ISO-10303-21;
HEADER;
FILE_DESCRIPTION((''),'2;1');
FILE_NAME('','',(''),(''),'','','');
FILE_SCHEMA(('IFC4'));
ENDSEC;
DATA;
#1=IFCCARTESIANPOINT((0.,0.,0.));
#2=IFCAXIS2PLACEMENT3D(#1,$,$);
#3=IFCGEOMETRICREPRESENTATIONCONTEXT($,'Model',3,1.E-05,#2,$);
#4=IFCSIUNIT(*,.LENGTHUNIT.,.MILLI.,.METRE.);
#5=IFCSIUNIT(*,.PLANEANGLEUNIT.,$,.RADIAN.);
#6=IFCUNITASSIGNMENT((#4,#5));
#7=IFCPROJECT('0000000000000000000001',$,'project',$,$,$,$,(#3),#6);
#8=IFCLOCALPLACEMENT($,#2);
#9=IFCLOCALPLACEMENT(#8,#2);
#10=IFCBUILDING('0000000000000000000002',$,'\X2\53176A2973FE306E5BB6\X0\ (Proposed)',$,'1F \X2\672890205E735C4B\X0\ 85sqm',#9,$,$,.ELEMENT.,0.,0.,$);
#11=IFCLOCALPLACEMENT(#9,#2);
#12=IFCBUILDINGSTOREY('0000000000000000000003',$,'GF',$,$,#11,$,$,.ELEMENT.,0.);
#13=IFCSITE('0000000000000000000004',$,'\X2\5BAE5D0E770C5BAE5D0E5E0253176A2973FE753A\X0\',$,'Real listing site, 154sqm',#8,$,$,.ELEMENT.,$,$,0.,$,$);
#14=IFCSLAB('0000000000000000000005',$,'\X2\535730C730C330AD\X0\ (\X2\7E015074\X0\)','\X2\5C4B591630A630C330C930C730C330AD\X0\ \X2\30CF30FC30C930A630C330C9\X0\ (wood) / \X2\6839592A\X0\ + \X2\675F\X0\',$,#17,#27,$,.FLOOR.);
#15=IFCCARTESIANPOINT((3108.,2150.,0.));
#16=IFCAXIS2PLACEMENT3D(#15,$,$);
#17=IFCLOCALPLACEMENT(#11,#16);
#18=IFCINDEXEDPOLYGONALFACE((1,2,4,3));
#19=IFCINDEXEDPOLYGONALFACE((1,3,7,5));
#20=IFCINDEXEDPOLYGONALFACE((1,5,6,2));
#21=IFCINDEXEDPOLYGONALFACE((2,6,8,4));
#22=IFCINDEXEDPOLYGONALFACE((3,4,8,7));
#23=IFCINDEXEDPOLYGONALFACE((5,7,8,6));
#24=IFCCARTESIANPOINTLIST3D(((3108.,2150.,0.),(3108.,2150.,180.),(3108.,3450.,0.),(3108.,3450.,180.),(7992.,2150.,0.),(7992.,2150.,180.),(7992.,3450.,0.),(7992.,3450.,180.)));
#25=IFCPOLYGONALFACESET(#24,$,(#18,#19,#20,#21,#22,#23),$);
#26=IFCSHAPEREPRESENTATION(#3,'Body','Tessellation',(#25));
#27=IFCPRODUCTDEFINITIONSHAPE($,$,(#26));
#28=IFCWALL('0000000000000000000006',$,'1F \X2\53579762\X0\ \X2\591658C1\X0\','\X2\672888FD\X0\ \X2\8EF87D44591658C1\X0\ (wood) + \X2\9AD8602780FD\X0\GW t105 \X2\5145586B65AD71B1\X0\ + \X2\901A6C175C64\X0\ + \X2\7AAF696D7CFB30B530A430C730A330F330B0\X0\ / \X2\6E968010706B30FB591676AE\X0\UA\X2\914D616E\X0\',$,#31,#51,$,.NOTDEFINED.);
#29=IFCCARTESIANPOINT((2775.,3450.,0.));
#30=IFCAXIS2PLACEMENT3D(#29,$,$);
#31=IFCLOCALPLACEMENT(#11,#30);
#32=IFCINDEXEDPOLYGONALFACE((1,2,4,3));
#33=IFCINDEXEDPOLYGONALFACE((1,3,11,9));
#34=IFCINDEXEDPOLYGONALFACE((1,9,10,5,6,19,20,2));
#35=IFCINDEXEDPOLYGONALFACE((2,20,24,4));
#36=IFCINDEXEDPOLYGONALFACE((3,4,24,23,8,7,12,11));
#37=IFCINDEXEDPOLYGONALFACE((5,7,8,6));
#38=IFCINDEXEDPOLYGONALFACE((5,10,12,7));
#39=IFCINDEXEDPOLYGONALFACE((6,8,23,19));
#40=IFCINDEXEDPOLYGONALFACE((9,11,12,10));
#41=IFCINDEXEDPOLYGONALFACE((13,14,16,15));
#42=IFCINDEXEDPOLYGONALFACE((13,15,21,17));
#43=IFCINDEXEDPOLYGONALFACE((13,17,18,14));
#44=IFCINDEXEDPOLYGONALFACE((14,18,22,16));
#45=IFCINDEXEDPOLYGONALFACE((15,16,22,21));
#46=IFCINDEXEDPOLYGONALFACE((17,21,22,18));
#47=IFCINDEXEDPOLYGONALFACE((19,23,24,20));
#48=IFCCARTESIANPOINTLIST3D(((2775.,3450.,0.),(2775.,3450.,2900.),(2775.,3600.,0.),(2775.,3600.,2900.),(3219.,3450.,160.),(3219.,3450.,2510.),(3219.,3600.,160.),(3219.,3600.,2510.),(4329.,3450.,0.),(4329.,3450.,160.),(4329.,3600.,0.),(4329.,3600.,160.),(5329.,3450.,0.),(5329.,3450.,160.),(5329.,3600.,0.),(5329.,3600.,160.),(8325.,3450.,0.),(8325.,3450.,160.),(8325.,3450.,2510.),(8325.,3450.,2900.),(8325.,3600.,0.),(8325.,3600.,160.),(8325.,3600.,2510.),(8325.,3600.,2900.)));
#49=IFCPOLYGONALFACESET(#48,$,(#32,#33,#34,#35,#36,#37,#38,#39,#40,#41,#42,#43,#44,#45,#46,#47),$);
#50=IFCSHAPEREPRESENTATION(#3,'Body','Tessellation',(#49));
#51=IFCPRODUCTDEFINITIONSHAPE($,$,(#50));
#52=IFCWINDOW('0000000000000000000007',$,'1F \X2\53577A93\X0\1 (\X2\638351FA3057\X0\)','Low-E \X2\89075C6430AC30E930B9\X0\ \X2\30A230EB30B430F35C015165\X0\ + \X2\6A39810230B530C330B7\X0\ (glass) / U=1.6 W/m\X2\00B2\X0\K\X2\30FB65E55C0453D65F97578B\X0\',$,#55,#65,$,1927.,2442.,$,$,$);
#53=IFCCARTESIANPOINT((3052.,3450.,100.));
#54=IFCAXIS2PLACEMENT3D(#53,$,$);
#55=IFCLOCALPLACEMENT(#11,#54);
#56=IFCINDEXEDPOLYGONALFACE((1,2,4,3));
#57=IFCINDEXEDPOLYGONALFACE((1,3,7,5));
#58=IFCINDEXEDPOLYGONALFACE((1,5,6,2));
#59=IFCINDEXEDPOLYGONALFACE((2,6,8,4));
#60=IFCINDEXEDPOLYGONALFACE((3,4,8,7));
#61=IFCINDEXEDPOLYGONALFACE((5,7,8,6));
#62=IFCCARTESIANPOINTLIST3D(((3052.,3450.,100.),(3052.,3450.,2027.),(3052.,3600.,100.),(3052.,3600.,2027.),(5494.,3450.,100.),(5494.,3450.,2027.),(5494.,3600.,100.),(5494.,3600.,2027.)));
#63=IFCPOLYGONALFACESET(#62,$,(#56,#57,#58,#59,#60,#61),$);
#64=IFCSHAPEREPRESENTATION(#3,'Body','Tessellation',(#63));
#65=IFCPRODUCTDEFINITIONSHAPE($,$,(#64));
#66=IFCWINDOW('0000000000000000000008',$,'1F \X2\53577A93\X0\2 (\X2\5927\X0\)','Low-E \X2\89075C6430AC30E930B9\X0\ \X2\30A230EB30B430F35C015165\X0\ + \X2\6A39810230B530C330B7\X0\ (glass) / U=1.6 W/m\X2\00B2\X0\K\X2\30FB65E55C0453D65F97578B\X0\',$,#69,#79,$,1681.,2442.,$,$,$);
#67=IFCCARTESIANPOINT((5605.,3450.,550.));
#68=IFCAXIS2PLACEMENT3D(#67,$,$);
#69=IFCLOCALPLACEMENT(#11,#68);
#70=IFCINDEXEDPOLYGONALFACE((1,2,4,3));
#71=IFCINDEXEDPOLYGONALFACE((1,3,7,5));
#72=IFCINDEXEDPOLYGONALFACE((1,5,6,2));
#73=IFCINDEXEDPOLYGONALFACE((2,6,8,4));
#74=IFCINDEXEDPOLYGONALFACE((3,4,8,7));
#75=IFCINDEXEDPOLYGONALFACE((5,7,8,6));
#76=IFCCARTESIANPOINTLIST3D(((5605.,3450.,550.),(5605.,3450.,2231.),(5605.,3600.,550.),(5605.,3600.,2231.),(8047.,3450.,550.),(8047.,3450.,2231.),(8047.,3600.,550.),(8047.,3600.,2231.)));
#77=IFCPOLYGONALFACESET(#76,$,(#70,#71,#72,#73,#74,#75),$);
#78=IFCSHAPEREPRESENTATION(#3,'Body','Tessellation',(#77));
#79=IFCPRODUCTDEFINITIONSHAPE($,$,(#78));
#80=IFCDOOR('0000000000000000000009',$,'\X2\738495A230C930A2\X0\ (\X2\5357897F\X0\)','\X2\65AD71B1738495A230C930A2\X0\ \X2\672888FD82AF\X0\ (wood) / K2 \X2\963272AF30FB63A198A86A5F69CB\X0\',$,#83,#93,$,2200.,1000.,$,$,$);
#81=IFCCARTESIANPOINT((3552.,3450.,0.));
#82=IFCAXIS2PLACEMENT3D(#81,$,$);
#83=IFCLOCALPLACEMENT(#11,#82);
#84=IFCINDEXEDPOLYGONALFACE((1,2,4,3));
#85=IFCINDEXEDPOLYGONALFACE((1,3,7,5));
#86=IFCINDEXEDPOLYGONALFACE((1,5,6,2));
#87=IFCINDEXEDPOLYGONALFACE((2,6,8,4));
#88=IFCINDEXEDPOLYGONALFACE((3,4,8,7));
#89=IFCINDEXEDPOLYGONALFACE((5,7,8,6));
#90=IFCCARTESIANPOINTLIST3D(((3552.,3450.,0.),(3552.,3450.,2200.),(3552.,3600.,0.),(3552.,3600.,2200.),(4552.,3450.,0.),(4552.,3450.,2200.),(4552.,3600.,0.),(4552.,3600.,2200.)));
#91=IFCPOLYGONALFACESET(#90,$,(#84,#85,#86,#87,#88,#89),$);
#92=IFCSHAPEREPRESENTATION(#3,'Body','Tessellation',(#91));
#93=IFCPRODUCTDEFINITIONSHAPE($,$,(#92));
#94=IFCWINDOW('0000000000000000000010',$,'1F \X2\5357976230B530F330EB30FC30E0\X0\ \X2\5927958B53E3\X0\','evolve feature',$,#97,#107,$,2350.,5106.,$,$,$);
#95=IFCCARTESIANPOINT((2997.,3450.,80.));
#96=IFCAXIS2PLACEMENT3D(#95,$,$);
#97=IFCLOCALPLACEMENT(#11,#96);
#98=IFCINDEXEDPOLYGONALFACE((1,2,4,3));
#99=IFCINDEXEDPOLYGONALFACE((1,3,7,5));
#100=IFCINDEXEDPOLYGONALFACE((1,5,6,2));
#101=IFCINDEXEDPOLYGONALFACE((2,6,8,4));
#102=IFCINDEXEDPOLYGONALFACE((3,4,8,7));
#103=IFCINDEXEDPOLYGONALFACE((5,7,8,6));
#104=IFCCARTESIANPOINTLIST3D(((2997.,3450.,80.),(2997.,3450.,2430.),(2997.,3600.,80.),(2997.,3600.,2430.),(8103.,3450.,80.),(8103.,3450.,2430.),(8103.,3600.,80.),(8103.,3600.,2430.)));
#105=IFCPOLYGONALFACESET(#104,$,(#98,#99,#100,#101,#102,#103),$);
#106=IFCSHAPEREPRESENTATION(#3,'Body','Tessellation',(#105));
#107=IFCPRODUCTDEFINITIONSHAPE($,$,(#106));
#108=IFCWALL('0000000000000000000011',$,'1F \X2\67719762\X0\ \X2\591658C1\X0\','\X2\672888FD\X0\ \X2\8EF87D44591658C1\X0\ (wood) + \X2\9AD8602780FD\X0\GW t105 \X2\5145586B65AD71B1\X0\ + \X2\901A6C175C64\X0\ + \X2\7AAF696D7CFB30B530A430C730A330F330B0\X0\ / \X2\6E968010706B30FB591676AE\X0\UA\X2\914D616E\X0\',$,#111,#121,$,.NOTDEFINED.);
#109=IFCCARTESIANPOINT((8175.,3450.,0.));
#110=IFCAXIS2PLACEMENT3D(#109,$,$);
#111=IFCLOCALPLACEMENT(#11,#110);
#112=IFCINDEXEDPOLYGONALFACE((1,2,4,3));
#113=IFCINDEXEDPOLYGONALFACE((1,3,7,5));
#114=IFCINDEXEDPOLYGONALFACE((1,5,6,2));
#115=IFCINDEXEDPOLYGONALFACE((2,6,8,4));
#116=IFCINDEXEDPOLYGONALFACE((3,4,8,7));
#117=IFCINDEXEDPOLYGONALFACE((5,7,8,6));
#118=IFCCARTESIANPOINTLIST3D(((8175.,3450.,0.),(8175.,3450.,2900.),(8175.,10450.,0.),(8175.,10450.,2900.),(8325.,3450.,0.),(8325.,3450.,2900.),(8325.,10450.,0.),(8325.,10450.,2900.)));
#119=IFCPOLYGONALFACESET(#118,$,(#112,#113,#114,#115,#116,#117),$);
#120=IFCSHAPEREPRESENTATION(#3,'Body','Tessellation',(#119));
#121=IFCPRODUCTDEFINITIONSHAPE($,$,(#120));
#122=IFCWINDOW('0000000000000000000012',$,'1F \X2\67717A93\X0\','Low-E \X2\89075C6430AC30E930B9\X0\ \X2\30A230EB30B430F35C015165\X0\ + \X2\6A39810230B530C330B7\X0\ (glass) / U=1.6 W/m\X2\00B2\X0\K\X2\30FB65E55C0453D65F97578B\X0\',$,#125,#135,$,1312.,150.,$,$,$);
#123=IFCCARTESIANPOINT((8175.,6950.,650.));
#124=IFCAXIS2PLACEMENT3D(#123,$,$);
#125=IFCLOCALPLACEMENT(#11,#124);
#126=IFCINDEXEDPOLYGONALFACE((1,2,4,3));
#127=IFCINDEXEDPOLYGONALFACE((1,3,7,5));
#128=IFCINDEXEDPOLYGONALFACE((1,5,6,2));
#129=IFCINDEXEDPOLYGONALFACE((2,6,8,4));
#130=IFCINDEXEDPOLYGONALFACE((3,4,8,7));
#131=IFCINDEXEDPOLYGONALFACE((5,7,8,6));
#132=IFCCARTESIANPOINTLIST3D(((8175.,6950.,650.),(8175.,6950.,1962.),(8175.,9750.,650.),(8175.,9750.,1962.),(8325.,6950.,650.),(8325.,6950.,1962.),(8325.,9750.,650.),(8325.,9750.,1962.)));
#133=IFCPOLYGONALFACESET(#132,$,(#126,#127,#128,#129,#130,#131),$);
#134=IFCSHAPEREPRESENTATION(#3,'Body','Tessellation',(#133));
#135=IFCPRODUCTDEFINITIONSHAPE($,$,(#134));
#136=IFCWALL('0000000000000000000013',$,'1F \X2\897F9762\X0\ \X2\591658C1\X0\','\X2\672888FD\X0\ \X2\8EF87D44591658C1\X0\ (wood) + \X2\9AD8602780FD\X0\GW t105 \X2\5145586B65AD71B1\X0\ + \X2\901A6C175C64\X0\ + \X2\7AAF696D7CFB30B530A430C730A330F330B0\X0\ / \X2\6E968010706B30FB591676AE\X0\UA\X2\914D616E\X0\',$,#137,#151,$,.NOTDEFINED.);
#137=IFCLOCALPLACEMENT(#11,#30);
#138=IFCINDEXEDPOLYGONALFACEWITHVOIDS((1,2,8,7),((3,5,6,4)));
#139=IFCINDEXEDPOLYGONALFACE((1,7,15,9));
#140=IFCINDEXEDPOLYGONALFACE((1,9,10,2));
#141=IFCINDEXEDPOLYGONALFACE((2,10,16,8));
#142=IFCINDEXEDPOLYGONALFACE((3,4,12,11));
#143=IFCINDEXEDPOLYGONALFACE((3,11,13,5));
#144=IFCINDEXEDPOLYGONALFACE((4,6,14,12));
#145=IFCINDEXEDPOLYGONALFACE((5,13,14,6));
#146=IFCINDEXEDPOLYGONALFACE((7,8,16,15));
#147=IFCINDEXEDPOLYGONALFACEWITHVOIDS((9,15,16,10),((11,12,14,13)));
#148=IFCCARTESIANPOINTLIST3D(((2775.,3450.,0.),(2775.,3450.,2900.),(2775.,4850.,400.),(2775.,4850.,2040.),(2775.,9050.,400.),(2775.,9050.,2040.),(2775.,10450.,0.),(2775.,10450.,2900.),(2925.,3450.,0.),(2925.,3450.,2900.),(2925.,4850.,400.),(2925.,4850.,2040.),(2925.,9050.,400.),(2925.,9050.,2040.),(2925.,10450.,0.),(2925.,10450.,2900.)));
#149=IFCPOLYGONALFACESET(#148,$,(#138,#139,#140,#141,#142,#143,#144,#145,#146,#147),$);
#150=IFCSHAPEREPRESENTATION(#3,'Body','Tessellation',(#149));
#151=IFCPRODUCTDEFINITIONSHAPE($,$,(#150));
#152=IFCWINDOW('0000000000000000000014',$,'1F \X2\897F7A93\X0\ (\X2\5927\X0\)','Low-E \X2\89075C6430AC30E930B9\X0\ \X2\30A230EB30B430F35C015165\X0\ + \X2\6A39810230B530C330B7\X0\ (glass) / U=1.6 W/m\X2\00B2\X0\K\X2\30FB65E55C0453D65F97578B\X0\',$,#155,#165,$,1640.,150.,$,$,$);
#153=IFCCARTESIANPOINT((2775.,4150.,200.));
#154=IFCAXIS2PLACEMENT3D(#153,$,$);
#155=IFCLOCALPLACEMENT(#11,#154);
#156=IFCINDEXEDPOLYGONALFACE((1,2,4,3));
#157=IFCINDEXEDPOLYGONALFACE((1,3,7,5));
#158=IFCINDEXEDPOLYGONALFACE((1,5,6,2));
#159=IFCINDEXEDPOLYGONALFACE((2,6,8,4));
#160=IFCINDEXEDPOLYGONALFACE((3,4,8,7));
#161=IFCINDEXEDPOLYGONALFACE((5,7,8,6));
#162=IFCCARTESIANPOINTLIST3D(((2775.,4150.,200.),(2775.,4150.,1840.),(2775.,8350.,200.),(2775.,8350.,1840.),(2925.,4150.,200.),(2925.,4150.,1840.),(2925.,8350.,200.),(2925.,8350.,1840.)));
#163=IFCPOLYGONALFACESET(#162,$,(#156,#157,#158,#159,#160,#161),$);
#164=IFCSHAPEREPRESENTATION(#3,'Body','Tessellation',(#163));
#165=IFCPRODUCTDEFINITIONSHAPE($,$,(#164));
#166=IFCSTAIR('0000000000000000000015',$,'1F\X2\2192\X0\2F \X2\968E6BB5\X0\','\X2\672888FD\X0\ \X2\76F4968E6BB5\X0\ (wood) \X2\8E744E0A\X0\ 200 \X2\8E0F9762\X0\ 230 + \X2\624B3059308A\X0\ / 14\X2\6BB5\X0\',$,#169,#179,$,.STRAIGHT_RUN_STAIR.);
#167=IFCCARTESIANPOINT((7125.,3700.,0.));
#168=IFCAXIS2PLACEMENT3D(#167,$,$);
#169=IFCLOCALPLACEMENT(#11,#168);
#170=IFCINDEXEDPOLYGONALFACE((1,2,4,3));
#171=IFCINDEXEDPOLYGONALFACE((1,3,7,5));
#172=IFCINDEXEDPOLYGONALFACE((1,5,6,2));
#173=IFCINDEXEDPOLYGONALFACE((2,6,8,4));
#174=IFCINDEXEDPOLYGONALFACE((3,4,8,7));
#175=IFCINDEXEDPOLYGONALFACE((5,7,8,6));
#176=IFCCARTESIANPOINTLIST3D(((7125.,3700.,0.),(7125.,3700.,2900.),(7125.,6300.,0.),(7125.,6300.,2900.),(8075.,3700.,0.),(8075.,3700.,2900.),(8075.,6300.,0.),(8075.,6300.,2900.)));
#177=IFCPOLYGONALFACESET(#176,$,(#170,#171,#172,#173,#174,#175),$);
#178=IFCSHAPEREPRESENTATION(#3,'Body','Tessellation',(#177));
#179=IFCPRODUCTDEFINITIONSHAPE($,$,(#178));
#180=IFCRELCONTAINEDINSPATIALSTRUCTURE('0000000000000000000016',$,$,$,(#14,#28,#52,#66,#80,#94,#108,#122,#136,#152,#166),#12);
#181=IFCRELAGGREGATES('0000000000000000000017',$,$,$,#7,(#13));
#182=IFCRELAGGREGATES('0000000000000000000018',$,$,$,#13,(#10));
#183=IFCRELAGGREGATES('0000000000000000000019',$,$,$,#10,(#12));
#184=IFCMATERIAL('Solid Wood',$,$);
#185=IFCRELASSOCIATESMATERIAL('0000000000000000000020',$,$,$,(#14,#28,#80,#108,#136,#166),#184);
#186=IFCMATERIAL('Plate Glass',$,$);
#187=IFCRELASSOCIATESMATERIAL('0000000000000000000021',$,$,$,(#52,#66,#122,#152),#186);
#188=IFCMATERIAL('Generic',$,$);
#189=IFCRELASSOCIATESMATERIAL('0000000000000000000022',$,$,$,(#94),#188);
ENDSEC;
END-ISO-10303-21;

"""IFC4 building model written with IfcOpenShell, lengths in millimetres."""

from ifc_helpers import new_model, si_unit, frame, frame_2d, origin, place, context, project, spatial, rectangle, extrude, material, element, fill, save


model = new_model("IFC4")

# Units and contexts
model_context = context("Model", 3, precision=1e-05, world=origin())
ifc_project = project(units=[si_unit("LENGTHUNIT", "METRE", prefix="MILLI"), si_unit("PLANEANGLEUNIT", "RADIAN")], contexts=[model_context])

# Site, building, storey
site_placement = place(None, origin())
site = spatial("IfcSite", under=ifc_project, at=site_placement, Name="宮崎県宮崎市北権現町", ObjectType="Real listing site, 154sqm", CompositionType="ELEMENT", RefElevation=0.0)
building_placement = place(site_placement, origin())
building = spatial("IfcBuilding", under=site, at=building_placement, Name="北権現の家 (Proposed)", ObjectType="1F 木造平屋 85sqm", CompositionType="ELEMENT", ElevationOfRefHeight=0.0, ElevationOfTerrain=0.0)
storey_placement = place(building_placement, origin())
storey = spatial("IfcBuildingStorey", under=building, at=storey_placement, Name="GF", CompositionType="ELEMENT", Elevation=0.0)

# Slab
ifc_material_1 = material(Name="Solid Wood")
slab_1_placement = place(storey_placement, frame((3108.0, 2150.0, 0.0)))
element("IfcSlab", 1, at=slab_1_placement, inside=storey, material=ifc_material_1, Name="南デッキ (縁側)", Description="屋外ウッドデッキ ハードウッド (wood) / 根太 + 束", PredefinedType="FLOOR", context=model_context, shape_type="SweptSolid", body=[
    extrude(rectangle(XDim=4884.0, YDim=1300.0, at=frame_2d((2442.0, 650.0))), frame((3108.0, 2150.0, 0.0)), (0.0, 0.0, 1.0), 180.0),
])
ifc_material_2 = material(Name="Generic")

# Wall, openings, windows, door
wall_1_placement = place(storey_placement, frame((2775.0, 3450.0, 0.0)))
wall_1 = element("IfcWall", 2, at=wall_1_placement, inside=storey, material=ifc_material_1, Name="1F 南面 外壁", Description="木製 軸組外壁 (wood) + 高性能GW t105 充填断熱 + 通気層 + 窯業系サイディング / 準耐火・外皮UA配慮", PredefinedType="NOTDEFINED", context=model_context, shape_type="SweptSolid", body=[
    extrude(rectangle(XDim=5550.0, YDim=150.0, at=frame_2d((2775.0, 75.0))), frame((2775.0, 3450.0, 0.0)), (0.0, 0.0, 1.0), 2900.0),
])
opening_1_placement = place(storey_placement, frame((3052.0, 3450.0, 100.0)))
opening_1 = element("IfcOpeningElement", 3, at=opening_1_placement, cuts=wall_1, PredefinedType="NOTDEFINED", context=model_context, shape_type="SweptSolid", body=[
    extrude(rectangle(XDim=2442.0, YDim=150.0, at=frame_2d((1221.0, 75.0))), frame((3052.0, 3450.0, 100.0)), (0.0, 0.0, 1.0), 1927.0),
])
opening_2_placement = place(storey_placement, frame((5605.0, 3450.0, 550.0)))
opening_2 = element("IfcOpeningElement", 4, at=opening_2_placement, cuts=wall_1, PredefinedType="NOTDEFINED", context=model_context, shape_type="SweptSolid", body=[
    extrude(rectangle(XDim=2442.0, YDim=150.0, at=frame_2d((1221.0, 75.0))), frame((5605.0, 3450.0, 550.0)), (0.0, 0.0, 1.0), 1681.0),
])
opening_3_placement = place(storey_placement, frame((3552.0, 3450.0, 0.0)))
opening_3 = element("IfcOpeningElement", 5, at=opening_3_placement, cuts=wall_1, PredefinedType="NOTDEFINED", context=model_context, shape_type="SweptSolid", body=[
    extrude(rectangle(XDim=1000.0, YDim=150.0, at=frame_2d((500.0, 75.0))), frame((3552.0, 3450.0, 0.0)), (0.0, 0.0, 1.0), 2200.0),
])
opening_4_placement = place(storey_placement, frame((2997.0, 3450.0, 80.0)))
opening_4 = element("IfcOpeningElement", 6, at=opening_4_placement, cuts=wall_1, PredefinedType="NOTDEFINED", context=model_context, shape_type="SweptSolid", body=[
    extrude(rectangle(XDim=5106.0, YDim=150.0, at=frame_2d((2553.0, 75.0))), frame((2997.0, 3450.0, 80.0)), (0.0, 0.0, 1.0), 2350.0),
])
ifc_material_3 = material(Name="Plate Glass")
window_1_placement = place(storey_placement, frame((3052.0, 3450.0, 100.0)))
window_1 = element("IfcWindow", 7, at=window_1_placement, inside=storey, material=ifc_material_3, Name="1F 南窓1 (掃出し)", Description="Low-E 複層ガラス アルゴン封入 + 樹脂サッシ (glass) / U=1.6 W/m²K・日射取得型", OverallHeight=1927.0, OverallWidth=2442.0, context=model_context, shape_type="SweptSolid", body=[
    extrude(rectangle(XDim=2442.0, YDim=150.0, at=frame_2d((1221.0, 75.0))), frame((3052.0, 3450.0, 100.0)), (0.0, 0.0, 1.0), 1927.0),
])
fill(opening_1, window_1)
window_2_placement = place(storey_placement, frame((5605.0, 3450.0, 550.0)))
window_2 = element("IfcWindow", 8, at=window_2_placement, inside=storey, material=ifc_material_3, Name="1F 南窓2 (大)", Description="Low-E 複層ガラス アルゴン封入 + 樹脂サッシ (glass) / U=1.6 W/m²K・日射取得型", OverallHeight=1681.0, OverallWidth=2442.0, context=model_context, shape_type="SweptSolid", body=[
    extrude(rectangle(XDim=2442.0, YDim=150.0, at=frame_2d((1221.0, 75.0))), frame((5605.0, 3450.0, 550.0)), (0.0, 0.0, 1.0), 1681.0),
])
fill(opening_2, window_2)
door_placement = place(storey_placement, frame((3552.0, 3450.0, 0.0)))
door = element("IfcDoor", 9, at=door_placement, inside=storey, material=ifc_material_1, Name="玄関ドア (南西)", Description="断熱玄関ドア 木製芯 (wood) / K2 防犯・採風機構", OverallHeight=2200.0, OverallWidth=1000.0, context=model_context, shape_type="SweptSolid", body=[
    extrude(rectangle(XDim=1000.0, YDim=150.0, at=frame_2d((500.0, 75.0))), frame((3552.0, 3450.0, 0.0)), (0.0, 0.0, 1.0), 2200.0),
])
fill(opening_3, door)
window_3_placement = place(storey_placement, frame((2997.0, 3450.0, 80.0)))
window_3 = element("IfcWindow", 10, at=window_3_placement, inside=storey, material=ifc_material_2, Name="1F 南面サンルーム 大開口", Description="evolve feature", OverallHeight=2350.0, OverallWidth=5106.0, context=model_context, shape_type="SweptSolid", body=[
    extrude(rectangle(XDim=5106.0, YDim=150.0, at=frame_2d((2553.0, 75.0))), frame((2997.0, 3450.0, 80.0)), (0.0, 0.0, 1.0), 2350.0),
])
fill(opening_4, window_3)

# Walls, openings, windows
wall_2_placement = place(storey_placement, frame((8175.0, 3450.0, 0.0)))
wall_2 = element("IfcWall", 11, at=wall_2_placement, inside=storey, material=ifc_material_1, Name="1F 東面 外壁", Description="木製 軸組外壁 (wood) + 高性能GW t105 充填断熱 + 通気層 + 窯業系サイディング / 準耐火・外皮UA配慮", PredefinedType="NOTDEFINED", context=model_context, shape_type="SweptSolid", body=[
    extrude(rectangle(XDim=150.0, YDim=7000.0, at=frame_2d((75.0, 3500.0))), frame((8175.0, 3450.0, 0.0)), (0.0, 0.0, 1.0), 2900.0),
])
opening_5_placement = place(storey_placement, frame((8175.0, 6950.0, 650.0)))
opening_5 = element("IfcOpeningElement", 12, at=opening_5_placement, cuts=wall_2, PredefinedType="NOTDEFINED", context=model_context, shape_type="SweptSolid", body=[
    extrude(rectangle(XDim=150.0, YDim=2800.0, at=frame_2d((75.0, 1400.0))), frame((8175.0, 6950.0, 650.0)), (0.0, 0.0, 1.0), 1312.0),
])
window_4_placement = place(storey_placement, frame((8175.0, 6950.0, 650.0)))
window_4 = element("IfcWindow", 13, at=window_4_placement, inside=storey, material=ifc_material_3, Name="1F 東窓", Description="Low-E 複層ガラス アルゴン封入 + 樹脂サッシ (glass) / U=1.6 W/m²K・日射取得型", OverallHeight=1312.0, OverallWidth=150.0, context=model_context, shape_type="SweptSolid", body=[
    extrude(rectangle(XDim=150.0, YDim=2800.0, at=frame_2d((75.0, 1400.0))), frame((8175.0, 6950.0, 650.0)), (0.0, 0.0, 1.0), 1312.0),
])
fill(opening_5, window_4)
wall_3_placement = place(storey_placement, frame((2775.0, 3450.0, 0.0)))
wall_3 = element("IfcWall", 14, at=wall_3_placement, inside=storey, material=ifc_material_1, Name="1F 西面 外壁", Description="木製 軸組外壁 (wood) + 高性能GW t105 充填断熱 + 通気層 + 窯業系サイディング / 準耐火・外皮UA配慮", PredefinedType="NOTDEFINED", context=model_context, shape_type="SweptSolid", body=[
    extrude(rectangle(XDim=150.0, YDim=7000.0, at=frame_2d((75.0, 3500.0))), frame((2775.0, 3450.0, 0.0)), (0.0, 0.0, 1.0), 2900.0),
])
opening_6_placement = place(storey_placement, frame((2775.0, 4150.0, 200.0)))
opening_6 = element("IfcOpeningElement", 15, at=opening_6_placement, cuts=wall_3, PredefinedType="NOTDEFINED", context=model_context, shape_type="SweptSolid", body=[
    extrude(rectangle(XDim=150.0, YDim=4200.0, at=frame_2d((75.0, 2100.0))), frame((2775.0, 4150.0, 200.0)), (0.0, 0.0, 1.0), 1640.0),
])
window_5_placement = place(storey_placement, frame((2775.0, 4150.0, 200.0)))
window_5 = element("IfcWindow", 16, at=window_5_placement, inside=storey, material=ifc_material_3, Name="1F 西窓 (大)", Description="Low-E 複層ガラス アルゴン封入 + 樹脂サッシ (glass) / U=1.6 W/m²K・日射取得型", OverallHeight=1640.0, OverallWidth=150.0, context=model_context, shape_type="SweptSolid", body=[
    extrude(rectangle(XDim=150.0, YDim=4200.0, at=frame_2d((75.0, 2100.0))), frame((2775.0, 4150.0, 200.0)), (0.0, 0.0, 1.0), 1640.0),
])
fill(opening_6, window_5)

# Stair
stair_placement = place(storey_placement, frame((7125.0, 3700.0, 0.0)))
element("IfcStair", 17, at=stair_placement, inside=storey, material=ifc_material_1, Name="1F→2F 階段", Description="木製 直階段 (wood) 蹴上 200 踏面 230 + 手すり / 14段", PredefinedType="STRAIGHT_RUN_STAIR", context=model_context, shape_type="SweptSolid", body=[
    extrude(rectangle(XDim=950.0, YDim=2600.0, at=frame_2d((475.0, 1300.0))), frame((7125.0, 3700.0, 0.0)), (0.0, 0.0, 1.0), 2900.0),
])

save(model, "model.ifc")
